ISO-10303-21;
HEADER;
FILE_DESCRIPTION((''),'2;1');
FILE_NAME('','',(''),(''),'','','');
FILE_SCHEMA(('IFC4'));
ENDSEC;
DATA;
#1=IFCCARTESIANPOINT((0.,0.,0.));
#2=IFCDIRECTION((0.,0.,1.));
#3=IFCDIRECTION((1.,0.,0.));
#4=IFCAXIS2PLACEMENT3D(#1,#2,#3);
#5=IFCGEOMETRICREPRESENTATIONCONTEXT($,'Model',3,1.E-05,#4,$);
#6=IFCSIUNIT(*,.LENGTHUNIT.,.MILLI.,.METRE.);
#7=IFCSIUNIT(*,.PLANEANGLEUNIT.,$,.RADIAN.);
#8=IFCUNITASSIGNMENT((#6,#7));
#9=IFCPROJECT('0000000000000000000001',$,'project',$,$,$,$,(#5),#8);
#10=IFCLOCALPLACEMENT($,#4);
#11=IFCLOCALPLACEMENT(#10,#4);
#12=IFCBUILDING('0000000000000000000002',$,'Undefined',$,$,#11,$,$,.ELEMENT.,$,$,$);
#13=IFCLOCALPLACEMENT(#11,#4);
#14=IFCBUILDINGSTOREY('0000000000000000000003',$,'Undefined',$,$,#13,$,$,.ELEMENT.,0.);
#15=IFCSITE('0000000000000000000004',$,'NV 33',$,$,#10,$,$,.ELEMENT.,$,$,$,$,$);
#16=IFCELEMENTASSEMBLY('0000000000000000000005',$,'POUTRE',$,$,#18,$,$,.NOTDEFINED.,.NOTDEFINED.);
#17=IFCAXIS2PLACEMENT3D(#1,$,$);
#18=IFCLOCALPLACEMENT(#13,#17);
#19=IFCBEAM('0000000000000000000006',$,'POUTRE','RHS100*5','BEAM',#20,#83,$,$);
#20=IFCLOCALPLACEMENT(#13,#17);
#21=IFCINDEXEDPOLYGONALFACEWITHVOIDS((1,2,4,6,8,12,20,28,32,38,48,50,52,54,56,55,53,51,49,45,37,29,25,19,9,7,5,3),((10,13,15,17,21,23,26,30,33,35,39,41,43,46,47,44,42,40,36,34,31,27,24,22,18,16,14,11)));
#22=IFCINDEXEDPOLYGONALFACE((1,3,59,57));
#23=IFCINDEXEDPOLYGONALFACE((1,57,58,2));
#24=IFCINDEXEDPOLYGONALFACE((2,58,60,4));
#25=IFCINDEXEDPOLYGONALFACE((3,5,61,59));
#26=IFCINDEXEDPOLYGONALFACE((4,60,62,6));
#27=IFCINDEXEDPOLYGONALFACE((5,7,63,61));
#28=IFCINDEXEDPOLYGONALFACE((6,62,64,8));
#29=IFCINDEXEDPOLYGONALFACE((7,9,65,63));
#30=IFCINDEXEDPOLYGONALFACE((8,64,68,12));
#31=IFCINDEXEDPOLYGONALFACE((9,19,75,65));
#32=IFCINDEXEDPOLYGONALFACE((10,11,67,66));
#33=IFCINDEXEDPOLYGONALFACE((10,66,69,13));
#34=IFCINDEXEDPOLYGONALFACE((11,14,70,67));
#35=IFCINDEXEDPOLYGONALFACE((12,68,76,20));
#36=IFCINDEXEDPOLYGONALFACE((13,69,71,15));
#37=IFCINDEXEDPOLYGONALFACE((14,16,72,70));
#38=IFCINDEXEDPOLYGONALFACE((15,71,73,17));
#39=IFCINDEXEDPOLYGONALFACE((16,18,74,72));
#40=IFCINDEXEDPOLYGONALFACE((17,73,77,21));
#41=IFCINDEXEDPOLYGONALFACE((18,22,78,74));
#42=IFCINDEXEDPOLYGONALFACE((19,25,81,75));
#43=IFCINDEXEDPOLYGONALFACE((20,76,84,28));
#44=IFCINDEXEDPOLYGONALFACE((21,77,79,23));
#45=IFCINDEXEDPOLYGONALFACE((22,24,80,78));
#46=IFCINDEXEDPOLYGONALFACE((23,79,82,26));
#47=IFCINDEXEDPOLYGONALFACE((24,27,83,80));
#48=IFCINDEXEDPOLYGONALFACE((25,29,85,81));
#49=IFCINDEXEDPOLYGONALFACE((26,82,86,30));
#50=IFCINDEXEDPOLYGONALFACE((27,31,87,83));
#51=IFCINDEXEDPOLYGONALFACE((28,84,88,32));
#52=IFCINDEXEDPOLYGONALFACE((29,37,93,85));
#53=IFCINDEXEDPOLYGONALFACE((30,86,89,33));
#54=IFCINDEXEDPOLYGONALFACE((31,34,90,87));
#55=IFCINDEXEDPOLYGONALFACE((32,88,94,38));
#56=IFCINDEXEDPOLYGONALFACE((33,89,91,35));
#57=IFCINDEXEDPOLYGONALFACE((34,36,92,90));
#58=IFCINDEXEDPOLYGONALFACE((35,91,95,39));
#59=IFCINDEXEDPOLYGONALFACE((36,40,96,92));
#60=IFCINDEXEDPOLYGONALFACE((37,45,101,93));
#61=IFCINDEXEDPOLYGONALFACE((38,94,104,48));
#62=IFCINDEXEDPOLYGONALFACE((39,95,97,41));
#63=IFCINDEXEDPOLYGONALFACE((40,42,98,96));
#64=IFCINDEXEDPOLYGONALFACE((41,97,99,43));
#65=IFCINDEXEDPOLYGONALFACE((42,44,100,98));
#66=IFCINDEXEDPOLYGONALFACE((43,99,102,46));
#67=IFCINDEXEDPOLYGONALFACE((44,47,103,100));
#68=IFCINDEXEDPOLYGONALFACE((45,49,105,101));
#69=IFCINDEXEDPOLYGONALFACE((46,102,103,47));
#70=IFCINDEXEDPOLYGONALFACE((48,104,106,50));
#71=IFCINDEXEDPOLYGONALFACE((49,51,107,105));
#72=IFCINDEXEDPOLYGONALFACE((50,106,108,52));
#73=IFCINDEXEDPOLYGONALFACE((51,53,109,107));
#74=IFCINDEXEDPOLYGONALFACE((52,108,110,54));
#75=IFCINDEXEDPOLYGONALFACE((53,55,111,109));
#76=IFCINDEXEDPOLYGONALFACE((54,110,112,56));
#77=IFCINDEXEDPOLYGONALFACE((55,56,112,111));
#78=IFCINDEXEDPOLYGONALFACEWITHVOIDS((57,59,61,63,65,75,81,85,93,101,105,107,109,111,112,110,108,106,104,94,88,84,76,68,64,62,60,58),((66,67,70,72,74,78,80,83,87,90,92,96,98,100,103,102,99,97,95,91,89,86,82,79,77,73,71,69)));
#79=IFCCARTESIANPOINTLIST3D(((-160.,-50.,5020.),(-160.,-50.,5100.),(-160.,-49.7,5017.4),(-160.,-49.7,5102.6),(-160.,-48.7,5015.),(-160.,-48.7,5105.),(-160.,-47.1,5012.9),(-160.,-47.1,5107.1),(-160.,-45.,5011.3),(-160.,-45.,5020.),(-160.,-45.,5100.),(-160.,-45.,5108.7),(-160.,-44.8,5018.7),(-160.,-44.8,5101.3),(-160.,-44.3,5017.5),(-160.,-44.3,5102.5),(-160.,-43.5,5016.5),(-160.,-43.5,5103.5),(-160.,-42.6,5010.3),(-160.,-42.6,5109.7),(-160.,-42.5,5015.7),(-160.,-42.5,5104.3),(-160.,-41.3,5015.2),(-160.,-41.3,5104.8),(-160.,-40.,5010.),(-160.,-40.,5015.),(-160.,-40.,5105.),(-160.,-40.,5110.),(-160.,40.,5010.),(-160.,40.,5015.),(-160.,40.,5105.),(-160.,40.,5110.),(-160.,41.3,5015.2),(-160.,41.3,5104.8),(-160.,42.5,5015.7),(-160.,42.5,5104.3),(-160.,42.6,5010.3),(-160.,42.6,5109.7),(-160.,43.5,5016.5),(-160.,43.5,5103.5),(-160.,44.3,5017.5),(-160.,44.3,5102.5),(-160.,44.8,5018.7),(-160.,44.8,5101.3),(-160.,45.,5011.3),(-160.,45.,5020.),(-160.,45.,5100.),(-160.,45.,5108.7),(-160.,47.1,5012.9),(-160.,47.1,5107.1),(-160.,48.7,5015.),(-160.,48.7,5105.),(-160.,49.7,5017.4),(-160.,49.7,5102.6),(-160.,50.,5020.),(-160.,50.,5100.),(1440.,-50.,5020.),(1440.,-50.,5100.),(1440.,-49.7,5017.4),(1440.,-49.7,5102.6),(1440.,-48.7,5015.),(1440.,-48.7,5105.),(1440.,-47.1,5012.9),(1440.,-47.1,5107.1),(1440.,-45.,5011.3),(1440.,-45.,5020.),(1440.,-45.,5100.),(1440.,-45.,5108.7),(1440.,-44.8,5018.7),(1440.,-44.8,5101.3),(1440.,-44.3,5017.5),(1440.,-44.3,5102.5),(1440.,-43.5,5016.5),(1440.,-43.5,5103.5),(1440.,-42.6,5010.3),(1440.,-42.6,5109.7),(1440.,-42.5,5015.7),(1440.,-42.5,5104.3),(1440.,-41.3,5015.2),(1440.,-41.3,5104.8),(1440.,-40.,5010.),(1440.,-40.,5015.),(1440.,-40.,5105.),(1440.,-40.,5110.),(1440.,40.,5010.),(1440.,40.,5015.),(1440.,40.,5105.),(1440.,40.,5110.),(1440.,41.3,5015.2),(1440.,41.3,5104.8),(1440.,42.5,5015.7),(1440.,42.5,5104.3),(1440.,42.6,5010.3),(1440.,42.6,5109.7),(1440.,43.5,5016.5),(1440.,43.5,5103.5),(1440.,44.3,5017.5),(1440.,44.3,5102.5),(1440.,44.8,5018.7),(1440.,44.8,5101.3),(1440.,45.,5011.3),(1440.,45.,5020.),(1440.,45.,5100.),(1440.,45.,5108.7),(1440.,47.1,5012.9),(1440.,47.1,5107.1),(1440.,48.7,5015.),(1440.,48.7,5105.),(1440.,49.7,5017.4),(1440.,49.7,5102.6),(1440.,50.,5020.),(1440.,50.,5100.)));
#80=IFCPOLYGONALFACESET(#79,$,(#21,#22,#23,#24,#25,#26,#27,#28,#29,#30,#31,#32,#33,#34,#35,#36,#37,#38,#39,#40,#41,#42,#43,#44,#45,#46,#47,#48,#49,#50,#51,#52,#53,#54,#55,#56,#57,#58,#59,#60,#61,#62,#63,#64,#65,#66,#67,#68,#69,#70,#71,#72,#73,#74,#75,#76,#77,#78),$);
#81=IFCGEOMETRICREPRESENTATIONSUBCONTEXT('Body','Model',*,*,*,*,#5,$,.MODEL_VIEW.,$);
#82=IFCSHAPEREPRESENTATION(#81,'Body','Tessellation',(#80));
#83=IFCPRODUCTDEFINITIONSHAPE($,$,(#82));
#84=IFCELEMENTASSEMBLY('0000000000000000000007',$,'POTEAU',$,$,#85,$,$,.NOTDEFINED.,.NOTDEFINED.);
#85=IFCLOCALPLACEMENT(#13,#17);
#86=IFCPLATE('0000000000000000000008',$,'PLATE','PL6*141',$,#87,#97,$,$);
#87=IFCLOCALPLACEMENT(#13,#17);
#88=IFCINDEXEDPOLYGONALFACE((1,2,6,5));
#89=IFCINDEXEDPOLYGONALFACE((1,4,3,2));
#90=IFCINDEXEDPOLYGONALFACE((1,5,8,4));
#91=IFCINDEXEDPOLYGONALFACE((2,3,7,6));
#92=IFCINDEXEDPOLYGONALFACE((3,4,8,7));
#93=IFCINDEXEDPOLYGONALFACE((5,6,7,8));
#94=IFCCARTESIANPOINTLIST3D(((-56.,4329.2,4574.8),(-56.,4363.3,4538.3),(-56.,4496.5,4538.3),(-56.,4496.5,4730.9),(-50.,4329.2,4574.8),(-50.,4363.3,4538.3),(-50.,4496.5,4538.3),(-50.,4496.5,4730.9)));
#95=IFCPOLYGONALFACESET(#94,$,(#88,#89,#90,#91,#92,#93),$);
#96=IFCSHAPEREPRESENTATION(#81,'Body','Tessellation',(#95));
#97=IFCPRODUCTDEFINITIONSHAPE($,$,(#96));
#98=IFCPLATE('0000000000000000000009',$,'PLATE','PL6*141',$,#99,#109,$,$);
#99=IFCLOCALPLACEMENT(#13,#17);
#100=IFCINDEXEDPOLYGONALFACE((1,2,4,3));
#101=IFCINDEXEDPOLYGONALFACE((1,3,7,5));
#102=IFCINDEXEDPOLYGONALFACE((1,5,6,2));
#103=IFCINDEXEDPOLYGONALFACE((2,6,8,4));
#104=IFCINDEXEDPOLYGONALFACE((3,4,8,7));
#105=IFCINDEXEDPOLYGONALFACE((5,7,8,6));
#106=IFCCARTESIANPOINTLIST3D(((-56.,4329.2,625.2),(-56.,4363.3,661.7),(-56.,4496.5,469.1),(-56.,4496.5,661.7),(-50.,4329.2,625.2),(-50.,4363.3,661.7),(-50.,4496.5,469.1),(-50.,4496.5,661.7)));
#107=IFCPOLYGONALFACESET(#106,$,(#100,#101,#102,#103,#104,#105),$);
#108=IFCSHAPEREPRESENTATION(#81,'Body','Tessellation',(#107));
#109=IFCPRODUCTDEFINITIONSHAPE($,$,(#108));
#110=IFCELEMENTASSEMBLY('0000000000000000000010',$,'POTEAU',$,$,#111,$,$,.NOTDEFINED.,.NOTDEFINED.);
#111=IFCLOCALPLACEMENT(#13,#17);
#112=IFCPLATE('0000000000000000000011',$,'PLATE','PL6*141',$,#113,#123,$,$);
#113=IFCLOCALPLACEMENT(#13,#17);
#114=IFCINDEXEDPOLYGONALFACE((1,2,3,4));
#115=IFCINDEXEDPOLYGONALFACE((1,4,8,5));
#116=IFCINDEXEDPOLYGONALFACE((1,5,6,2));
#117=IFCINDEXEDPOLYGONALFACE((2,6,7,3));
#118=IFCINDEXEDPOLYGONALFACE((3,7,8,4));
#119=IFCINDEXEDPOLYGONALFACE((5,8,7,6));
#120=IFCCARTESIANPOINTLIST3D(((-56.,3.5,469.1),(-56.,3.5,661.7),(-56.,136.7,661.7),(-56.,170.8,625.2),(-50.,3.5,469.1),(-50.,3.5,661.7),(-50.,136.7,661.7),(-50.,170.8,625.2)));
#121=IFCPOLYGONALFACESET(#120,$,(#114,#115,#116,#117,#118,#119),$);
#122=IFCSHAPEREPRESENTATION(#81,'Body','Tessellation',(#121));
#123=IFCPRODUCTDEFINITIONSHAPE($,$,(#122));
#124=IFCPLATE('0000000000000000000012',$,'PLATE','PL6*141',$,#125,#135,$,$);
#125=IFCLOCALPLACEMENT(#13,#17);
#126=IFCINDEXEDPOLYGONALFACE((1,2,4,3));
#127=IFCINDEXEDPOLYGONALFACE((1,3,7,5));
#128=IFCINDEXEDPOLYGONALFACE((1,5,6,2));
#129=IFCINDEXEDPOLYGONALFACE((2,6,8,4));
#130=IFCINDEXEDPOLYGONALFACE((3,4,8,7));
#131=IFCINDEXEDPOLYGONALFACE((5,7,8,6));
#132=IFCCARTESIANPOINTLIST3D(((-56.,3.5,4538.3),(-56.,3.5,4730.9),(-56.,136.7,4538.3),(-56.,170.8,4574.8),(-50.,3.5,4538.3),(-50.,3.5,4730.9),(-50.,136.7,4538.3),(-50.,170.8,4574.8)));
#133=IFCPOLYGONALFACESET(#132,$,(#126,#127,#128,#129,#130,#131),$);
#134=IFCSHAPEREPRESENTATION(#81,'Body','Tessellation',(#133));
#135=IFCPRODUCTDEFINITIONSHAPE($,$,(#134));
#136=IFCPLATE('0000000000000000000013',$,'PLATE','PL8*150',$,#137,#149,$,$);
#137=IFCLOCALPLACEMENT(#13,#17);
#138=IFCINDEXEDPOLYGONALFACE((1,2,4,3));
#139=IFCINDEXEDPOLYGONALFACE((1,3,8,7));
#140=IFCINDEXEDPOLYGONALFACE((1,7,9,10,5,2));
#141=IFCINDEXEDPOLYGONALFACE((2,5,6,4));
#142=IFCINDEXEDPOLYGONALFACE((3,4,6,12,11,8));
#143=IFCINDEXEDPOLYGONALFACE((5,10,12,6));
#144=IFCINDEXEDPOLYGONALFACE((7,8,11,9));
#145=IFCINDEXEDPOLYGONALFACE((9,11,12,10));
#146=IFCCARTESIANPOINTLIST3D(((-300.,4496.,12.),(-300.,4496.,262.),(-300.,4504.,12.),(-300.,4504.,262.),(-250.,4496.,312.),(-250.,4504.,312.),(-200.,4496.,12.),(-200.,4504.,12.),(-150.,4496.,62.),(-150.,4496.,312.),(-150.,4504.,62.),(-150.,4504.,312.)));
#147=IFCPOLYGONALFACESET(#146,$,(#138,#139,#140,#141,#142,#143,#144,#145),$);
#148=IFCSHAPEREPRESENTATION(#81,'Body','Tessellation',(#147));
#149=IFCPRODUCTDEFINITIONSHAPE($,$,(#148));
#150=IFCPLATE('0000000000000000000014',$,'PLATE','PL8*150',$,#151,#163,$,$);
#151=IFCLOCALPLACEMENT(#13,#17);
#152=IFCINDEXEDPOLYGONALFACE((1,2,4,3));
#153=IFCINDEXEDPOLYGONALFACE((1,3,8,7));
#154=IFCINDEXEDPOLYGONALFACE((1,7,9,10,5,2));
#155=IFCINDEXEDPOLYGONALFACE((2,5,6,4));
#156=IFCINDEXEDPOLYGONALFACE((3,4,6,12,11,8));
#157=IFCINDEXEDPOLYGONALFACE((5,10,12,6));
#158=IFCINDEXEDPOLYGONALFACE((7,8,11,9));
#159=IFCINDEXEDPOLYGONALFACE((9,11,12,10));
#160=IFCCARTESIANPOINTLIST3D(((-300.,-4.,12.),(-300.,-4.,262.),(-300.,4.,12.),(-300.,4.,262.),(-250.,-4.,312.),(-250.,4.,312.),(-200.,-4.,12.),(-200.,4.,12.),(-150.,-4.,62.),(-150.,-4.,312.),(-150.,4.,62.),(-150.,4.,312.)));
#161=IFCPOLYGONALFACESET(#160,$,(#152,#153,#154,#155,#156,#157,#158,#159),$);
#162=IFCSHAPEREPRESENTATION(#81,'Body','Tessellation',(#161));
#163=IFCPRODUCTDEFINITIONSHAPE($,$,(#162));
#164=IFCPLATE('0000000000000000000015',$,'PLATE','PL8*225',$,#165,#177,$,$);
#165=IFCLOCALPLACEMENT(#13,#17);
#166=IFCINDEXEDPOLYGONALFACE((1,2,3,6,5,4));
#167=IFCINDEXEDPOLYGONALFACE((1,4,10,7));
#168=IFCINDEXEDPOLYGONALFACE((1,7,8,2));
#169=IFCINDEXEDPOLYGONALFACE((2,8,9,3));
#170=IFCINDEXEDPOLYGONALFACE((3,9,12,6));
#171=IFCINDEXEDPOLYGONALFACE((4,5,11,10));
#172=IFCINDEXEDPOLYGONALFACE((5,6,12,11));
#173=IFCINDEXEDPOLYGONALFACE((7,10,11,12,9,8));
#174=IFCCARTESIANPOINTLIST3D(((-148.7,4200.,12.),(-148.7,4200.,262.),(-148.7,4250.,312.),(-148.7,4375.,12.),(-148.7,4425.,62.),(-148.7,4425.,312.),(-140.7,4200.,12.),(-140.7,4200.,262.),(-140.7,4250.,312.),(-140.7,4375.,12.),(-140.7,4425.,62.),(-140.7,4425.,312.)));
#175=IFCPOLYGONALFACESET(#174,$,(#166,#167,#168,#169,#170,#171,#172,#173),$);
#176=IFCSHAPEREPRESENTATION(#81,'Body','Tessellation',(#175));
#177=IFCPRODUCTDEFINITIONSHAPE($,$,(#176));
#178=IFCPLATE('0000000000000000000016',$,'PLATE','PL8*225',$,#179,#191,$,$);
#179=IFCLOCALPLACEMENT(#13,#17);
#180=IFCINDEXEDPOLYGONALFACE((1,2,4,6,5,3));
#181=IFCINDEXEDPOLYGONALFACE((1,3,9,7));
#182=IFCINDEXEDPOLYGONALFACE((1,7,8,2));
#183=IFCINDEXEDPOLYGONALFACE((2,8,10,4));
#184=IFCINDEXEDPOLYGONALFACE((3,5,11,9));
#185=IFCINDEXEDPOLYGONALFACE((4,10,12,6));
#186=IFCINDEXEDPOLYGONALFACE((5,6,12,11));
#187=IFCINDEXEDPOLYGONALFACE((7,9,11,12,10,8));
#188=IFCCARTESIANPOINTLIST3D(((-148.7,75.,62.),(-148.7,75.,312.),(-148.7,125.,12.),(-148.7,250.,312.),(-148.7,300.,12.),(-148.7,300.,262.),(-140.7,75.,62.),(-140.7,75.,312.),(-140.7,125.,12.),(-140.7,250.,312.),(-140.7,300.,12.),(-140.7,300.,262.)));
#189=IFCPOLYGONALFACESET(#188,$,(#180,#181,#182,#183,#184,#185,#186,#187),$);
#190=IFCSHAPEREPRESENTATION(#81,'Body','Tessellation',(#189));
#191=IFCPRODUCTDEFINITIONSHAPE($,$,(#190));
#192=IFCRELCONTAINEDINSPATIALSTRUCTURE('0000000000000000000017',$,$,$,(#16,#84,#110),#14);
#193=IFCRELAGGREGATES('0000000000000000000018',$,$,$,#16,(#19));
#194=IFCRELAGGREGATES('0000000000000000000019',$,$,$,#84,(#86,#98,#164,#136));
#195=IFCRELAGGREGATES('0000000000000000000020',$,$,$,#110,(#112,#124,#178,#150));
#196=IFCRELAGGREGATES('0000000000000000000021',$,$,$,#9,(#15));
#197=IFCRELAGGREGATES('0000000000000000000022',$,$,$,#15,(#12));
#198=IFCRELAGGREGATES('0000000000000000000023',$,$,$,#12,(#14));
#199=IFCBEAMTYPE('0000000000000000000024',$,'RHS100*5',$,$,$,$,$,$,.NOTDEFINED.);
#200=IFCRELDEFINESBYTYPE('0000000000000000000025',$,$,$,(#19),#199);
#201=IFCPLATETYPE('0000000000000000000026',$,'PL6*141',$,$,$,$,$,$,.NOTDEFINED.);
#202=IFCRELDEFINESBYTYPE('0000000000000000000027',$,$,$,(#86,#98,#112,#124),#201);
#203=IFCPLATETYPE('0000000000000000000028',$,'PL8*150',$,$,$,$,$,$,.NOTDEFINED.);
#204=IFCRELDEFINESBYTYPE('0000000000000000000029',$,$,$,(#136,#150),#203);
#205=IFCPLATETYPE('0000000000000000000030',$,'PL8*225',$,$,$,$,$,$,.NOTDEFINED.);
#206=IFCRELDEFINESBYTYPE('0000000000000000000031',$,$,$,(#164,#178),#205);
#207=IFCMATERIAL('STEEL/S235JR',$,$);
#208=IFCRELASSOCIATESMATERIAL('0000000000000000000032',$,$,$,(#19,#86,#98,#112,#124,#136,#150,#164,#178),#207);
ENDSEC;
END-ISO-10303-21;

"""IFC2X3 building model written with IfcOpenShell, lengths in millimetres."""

from ifc_helpers import new_model, si_unit, frame, origin_with_axes, origin_2d_with_axis, place, context, subcontext, project, spatial, polyline, hollow_rectangle, outline, extrude, material, type_object, element, aggregate, save


model = new_model("IFC2X3")

# Units and contexts
model_context = context("Model", 3, precision=1e-05, world=origin_with_axes())
body_context = subcontext(model_context, "Body", "Model", "MODEL_VIEW")
ifc_project = project(units=[si_unit("LENGTHUNIT", "METRE", prefix="MILLI"), si_unit("PLANEANGLEUNIT", "RADIAN")], contexts=[model_context])

# Site, building, storey
site_placement = place(None, origin_with_axes())
site = spatial("IfcSite", under=ifc_project, at=site_placement, Name="NV 33", CompositionType="ELEMENT")
building_placement = place(site_placement, origin_with_axes())
building = spatial("IfcBuilding", under=site, at=building_placement, Name="Undefined", CompositionType="ELEMENT")
storey_placement = place(building_placement, origin_with_axes())
storey = spatial("IfcBuildingStorey", under=building, at=storey_placement, Name="Undefined", CompositionType="ELEMENT", Elevation=0.0)

# Shared definitions
ifc_material_1 = material(Name="STEEL/S235JR")

# Element assembly, beam
beam_type_1 = type_object("IfcBeamType", Name="RHS100*5", PredefinedType="NOTDEFINED")
assembly_1_placement = place(storey_placement, origin_with_axes())
assembly_1 = element("IfcElementAssembly", 1, at=assembly_1_placement, inside=storey, Name="POUTRE", AssemblyPlace="NOTDEFINED", PredefinedType="NOTDEFINED")
beam_1_placement = place(assembly_1_placement, frame((-160.0, 0.0, 5060.0), z_axis=(0.0, -1.0, 0.0), x_axis=(1.0, 0.0, 0.0)))
beam_1 = element("IfcBeam", 2, at=beam_1_placement, type_object=beam_type_1, material=ifc_material_1, Name="POUTRE", Description="RHS100*5", ObjectType="BEAM", context=body_context, shape_type="SweptSolid", body=[
    extrude(hollow_rectangle(XDim=100.0, YDim=100.0, WallThickness=5.0, InnerFilletRadius=5.0, OuterFilletRadius=10.0, at=origin_2d_with_axis()), frame((1600.0, 0.0, 0.0), z_axis=(-1.0, 0.0, 0.0), x_axis=(0.0, -1.0, 0.0)), (0.0, 0.0, 1.0), 1600.0),
])
aggregate(assembly_1, [beam_1])

# Element assemblies, plates
assembly_2_placement = place(storey_placement, origin_with_axes())
assembly_2 = element("IfcElementAssembly", 3, at=assembly_2_placement, inside=storey, Name="POTEAU", AssemblyPlace="NOTDEFINED", PredefinedType="NOTDEFINED")
plate_type_1 = type_object("IfcPlateType", Name="PL6*141", PredefinedType="NOTDEFINED")
plate_1_placement = place(assembly_2_placement, frame((-53.0, 4496.5, 4538.3), z_axis=(1.0, 0.0, 0.0), x_axis=(0.0, 0.0, 1.0)))
plate_1 = element("IfcPlate", 4, at=plate_1_placement, type_object=plate_type_1, material=ifc_material_1, Name="PLATE", Description="PL6*141", context=body_context, shape_type="SweptSolid", body=[
    extrude(outline(polyline([(0.0, 0.0), (192.6, 0.0), (36.6, 167.2), (0.0, 133.1), (0.0, 0.0)])), frame((0.0, 0.0, -3.0), z_axis=(0.0, 0.0, 1.0), x_axis=(1.0, 0.0, 0.0)), (0.0, 0.0, 1.0), 6.0),
])
plate_2_placement = place(assembly_2_placement, frame((-53.0, 4496.5, 469.1), z_axis=(1.0, 0.0, 0.0), x_axis=(0.0, 0.0, 1.0)))
plate_2 = element("IfcPlate", 5, at=plate_2_placement, type_object=plate_type_1, material=ifc_material_1, Name="PLATE", Description="PL6*141", context=body_context, shape_type="SweptSolid", body=[
    extrude(outline(polyline([(0.0, 0.0), (192.6, 0.0), (192.6, 133.1), (156.1, 167.2), (0.0, 0.0)])), frame((0.0, 0.0, -3.0), z_axis=(0.0, 0.0, 1.0), x_axis=(1.0, 0.0, 0.0)), (0.0, 0.0, 1.0), 6.0),
])
assembly_3_placement = place(storey_placement, origin_with_axes())
assembly_3 = element("IfcElementAssembly", 6, at=assembly_3_placement, inside=storey, Name="POTEAU", AssemblyPlace="NOTDEFINED", PredefinedType="NOTDEFINED")
plate_3_placement = place(assembly_3_placement, frame((-53.0, 3.5, 661.7), z_axis=(1.0, 0.0, 0.0), x_axis=(0.0, 0.0, -1.0)))
plate_3 = element("IfcPlate", 7, at=plate_3_placement, type_object=plate_type_1, material=ifc_material_1, Name="PLATE", Description="PL6*141", context=body_context, shape_type="SweptSolid", body=[
    extrude(outline(polyline([(0.0, 0.0), (192.6, 0.0), (36.6, 167.2), (0.0, 133.1), (0.0, 0.0)])), frame((0.0, 0.0, -3.0), z_axis=(0.0, 0.0, 1.0), x_axis=(1.0, 0.0, 0.0)), (0.0, 0.0, 1.0), 6.0),
])
plate_4_placement = place(assembly_3_placement, frame((-53.0, 3.5, 4730.9), z_axis=(1.0, 0.0, 0.0), x_axis=(0.0, 0.0, -1.0)))
plate_4 = element("IfcPlate", 8, at=plate_4_placement, type_object=plate_type_1, material=ifc_material_1, Name="PLATE", Description="PL6*141", context=body_context, shape_type="SweptSolid", body=[
    extrude(outline(polyline([(0.0, 0.0), (192.6, 0.0), (192.6, 133.1), (156.1, 167.2), (0.0, 0.0)])), frame((0.0, 0.0, -3.0), z_axis=(0.0, 0.0, 1.0), x_axis=(1.0, 0.0, 0.0)), (0.0, 0.0, 1.0), 6.0),
])

# Plates
plate_type_2 = type_object("IfcPlateType", Name="PL8*150", PredefinedType="NOTDEFINED")
plate_5_placement = place(assembly_2_placement, frame((-150.0, 4500.0, 12.0), z_axis=(0.0, 1.0, 0.0), x_axis=(-1.0, 0.0, 0.0)))
plate_5 = element("IfcPlate", 9, at=plate_5_placement, type_object=plate_type_2, material=ifc_material_1, Name="PLATE", Description="PL8*150", context=body_context, shape_type="SweptSolid", body=[
    extrude(outline(polyline([(0.0, 50.0), (50.0, 0.0), (150.0, 0.0), (150.0, 250.0), (100.0, 300.0), (0.0, 300.0), (0.0, 50.0)])), frame((0.0, 0.0, -4.0), z_axis=(0.0, 0.0, 1.0), x_axis=(1.0, 0.0, 0.0)), (0.0, 0.0, 1.0), 8.0),
])
plate_6_placement = place(assembly_3_placement, frame((-150.0, 0.0, 12.0), z_axis=(0.0, 1.0, 0.0), x_axis=(-1.0, 0.0, 0.0)))
plate_6 = element("IfcPlate", 10, at=plate_6_placement, type_object=plate_type_2, material=ifc_material_1, Name="PLATE", Description="PL8*150", context=body_context, shape_type="SweptSolid", body=[
    extrude(outline(polyline([(0.0, 50.0), (50.0, 0.0), (150.0, 0.0), (150.0, 250.0), (100.0, 300.0), (0.0, 300.0), (0.0, 50.0)])), frame((0.0, 0.0, -4.0), z_axis=(0.0, 0.0, 1.0), x_axis=(1.0, 0.0, 0.0)), (0.0, 0.0, 1.0), 8.0),
])
plate_type_3 = type_object("IfcPlateType", Name="PL8*225", PredefinedType="NOTDEFINED")
plate_7_placement = place(assembly_2_placement, frame((-144.7, 4425.0, 12.0), z_axis=(-1.0, 0.0, 0.0), x_axis=(0.0, -1.0, 0.0)))
plate_7 = element("IfcPlate", 11, at=plate_7_placement, type_object=plate_type_3, material=ifc_material_1, Name="PLATE", Description="PL8*225", context=body_context, shape_type="SweptSolid", body=[
    extrude(outline(polyline([(0.0, 50.0), (50.0, 0.0), (225.0, 0.0), (225.0, 250.0), (175.0, 300.0), (0.0, 300.0), (0.0, 50.0)])), frame((0.0, 0.0, -4.0), z_axis=(0.0, 0.0, 1.0), x_axis=(1.0, 0.0, 0.0)), (0.0, 0.0, 1.0), 8.0),
])
plate_8_placement = place(assembly_3_placement, frame((-144.7, 75.0, 12.0), z_axis=(1.0, 0.0, 0.0), x_axis=(0.0, 1.0, 0.0)))
plate_8 = element("IfcPlate", 12, at=plate_8_placement, type_object=plate_type_3, material=ifc_material_1, Name="PLATE", Description="PL8*225", context=body_context, shape_type="SweptSolid", body=[
    extrude(outline(polyline([(0.0, 50.0), (50.0, 0.0), (225.0, 0.0), (225.0, 250.0), (175.0, 300.0), (0.0, 300.0), (0.0, 50.0)])), frame((0.0, 0.0, -4.0), z_axis=(0.0, 0.0, 1.0), x_axis=(1.0, 0.0, 0.0)), (0.0, 0.0, 1.0), 8.0),
])

aggregate(assembly_2, [plate_1, plate_2, plate_7, plate_5])
aggregate(assembly_3, [plate_3, plate_4, plate_8, plate_6])

save(model, "model.ifc")
